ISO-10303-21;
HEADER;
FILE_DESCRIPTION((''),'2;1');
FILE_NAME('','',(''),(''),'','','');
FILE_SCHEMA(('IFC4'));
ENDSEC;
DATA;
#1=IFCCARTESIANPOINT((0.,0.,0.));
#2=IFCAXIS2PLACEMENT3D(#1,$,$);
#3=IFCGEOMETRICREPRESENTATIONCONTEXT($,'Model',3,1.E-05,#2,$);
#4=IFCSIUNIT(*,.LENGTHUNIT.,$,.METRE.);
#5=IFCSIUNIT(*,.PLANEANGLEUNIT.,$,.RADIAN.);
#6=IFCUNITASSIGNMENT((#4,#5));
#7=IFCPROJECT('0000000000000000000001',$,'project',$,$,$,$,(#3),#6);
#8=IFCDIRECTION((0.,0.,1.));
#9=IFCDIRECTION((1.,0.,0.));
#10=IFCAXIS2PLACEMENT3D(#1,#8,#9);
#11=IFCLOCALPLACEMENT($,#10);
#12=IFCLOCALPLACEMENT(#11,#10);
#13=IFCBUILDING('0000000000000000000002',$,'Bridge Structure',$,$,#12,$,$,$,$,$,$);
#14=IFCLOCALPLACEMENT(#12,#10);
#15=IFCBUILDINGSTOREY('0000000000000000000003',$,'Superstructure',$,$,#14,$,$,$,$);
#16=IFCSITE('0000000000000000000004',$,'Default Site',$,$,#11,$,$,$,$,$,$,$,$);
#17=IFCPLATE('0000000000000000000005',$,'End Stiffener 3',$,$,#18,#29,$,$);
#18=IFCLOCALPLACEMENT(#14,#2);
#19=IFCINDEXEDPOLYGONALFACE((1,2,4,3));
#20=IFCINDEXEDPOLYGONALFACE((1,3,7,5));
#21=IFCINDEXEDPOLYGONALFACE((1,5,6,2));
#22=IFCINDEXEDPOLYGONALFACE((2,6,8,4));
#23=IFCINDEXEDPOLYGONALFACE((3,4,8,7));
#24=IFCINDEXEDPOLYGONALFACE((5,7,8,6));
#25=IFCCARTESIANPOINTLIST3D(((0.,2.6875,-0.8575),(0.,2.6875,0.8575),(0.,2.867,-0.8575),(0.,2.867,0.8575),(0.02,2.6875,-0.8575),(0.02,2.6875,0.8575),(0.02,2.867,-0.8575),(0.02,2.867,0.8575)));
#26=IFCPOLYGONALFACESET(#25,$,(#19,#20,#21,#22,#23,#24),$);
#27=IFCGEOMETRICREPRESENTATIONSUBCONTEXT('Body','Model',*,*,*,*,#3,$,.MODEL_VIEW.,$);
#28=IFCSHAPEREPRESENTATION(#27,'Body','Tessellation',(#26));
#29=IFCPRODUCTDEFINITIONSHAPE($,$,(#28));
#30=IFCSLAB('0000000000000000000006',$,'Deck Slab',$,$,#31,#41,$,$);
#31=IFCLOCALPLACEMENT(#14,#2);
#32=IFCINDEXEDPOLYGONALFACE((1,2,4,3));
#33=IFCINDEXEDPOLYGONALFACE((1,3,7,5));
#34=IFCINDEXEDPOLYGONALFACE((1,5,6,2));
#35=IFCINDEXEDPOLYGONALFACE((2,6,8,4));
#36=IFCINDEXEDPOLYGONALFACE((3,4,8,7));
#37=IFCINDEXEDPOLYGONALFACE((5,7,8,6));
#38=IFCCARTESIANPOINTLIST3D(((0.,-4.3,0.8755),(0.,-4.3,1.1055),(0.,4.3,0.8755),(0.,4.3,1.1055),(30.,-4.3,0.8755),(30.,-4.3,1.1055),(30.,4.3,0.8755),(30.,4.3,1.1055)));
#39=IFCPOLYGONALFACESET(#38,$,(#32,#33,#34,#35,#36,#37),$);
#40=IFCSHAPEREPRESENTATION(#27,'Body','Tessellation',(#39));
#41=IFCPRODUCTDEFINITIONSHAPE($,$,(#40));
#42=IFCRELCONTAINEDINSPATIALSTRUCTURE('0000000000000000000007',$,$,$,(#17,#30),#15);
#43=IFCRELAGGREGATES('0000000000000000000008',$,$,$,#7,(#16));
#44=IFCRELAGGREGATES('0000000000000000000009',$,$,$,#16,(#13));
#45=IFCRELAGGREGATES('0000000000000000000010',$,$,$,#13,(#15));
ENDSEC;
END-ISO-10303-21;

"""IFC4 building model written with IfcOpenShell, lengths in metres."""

from ifc_helpers import new_model, si_unit, frame, origin, origin_with_axes, origin_2d_with_axis, place, context, subcontext, project, spatial, polyline, rectangle, outline, extrude, element, save


model = new_model("IFC4")

# Units and contexts
model_context = context("Model", 3, precision=1e-05, world=origin())
body_context = subcontext(model_context, "Body", "Model", "MODEL_VIEW")
ifc_project = project(units=[si_unit("LENGTHUNIT", "METRE"), si_unit("PLANEANGLEUNIT", "RADIAN")], contexts=[model_context])

# Site, building, storey
site_placement = place(None, origin_with_axes())
site = spatial("IfcSite", under=ifc_project, at=site_placement, Name="Default Site")
building_placement = place(site_placement, origin_with_axes())
building = spatial("IfcBuilding", under=site, at=building_placement, Name="Bridge Structure")
storey_placement = place(building_placement, origin_with_axes())
storey = spatial("IfcBuildingStorey", under=building, at=storey_placement, Name="Superstructure")

# Plate
for number, where, z_axis, x_axis, name in (
    (1, (0.01, 2.7772, -0.8575), (0.0, 0.0, 1.0), (1.0, 0.0, 0.0), "End Stiffener 3"),
):
    element("IfcPlate", number, at=place(storey_placement, frame(where, z_axis=z_axis, x_axis=x_axis)), inside=storey, Name=name, context=body_context, shape_type="SweptSolid", body=[
        extrude(rectangle(XDim=0.02, YDim=0.1795, at=origin_2d_with_axis()), origin_with_axes(), (0.0, 0.0, 1.0), 1.715),
    ])

# Slab
slab_placement = place(storey_placement, frame((0.0, 0.0, 0.8755), z_axis=(0.0, 0.0, 1.0), x_axis=(1.0, 0.0, 0.0)))
element("IfcSlab", 2, at=slab_placement, inside=storey, Name="Deck Slab", context=body_context, shape_type="SweptSolid", body=[
    extrude(outline(polyline([(0.0, -4.3), (30.0, -4.3), (30.0, 4.3), (0.0, 4.3), (0.0, -4.3)])), origin_with_axes(), (0.0, 0.0, 1.0), 0.23),
])

save(model, "model.ifc")
